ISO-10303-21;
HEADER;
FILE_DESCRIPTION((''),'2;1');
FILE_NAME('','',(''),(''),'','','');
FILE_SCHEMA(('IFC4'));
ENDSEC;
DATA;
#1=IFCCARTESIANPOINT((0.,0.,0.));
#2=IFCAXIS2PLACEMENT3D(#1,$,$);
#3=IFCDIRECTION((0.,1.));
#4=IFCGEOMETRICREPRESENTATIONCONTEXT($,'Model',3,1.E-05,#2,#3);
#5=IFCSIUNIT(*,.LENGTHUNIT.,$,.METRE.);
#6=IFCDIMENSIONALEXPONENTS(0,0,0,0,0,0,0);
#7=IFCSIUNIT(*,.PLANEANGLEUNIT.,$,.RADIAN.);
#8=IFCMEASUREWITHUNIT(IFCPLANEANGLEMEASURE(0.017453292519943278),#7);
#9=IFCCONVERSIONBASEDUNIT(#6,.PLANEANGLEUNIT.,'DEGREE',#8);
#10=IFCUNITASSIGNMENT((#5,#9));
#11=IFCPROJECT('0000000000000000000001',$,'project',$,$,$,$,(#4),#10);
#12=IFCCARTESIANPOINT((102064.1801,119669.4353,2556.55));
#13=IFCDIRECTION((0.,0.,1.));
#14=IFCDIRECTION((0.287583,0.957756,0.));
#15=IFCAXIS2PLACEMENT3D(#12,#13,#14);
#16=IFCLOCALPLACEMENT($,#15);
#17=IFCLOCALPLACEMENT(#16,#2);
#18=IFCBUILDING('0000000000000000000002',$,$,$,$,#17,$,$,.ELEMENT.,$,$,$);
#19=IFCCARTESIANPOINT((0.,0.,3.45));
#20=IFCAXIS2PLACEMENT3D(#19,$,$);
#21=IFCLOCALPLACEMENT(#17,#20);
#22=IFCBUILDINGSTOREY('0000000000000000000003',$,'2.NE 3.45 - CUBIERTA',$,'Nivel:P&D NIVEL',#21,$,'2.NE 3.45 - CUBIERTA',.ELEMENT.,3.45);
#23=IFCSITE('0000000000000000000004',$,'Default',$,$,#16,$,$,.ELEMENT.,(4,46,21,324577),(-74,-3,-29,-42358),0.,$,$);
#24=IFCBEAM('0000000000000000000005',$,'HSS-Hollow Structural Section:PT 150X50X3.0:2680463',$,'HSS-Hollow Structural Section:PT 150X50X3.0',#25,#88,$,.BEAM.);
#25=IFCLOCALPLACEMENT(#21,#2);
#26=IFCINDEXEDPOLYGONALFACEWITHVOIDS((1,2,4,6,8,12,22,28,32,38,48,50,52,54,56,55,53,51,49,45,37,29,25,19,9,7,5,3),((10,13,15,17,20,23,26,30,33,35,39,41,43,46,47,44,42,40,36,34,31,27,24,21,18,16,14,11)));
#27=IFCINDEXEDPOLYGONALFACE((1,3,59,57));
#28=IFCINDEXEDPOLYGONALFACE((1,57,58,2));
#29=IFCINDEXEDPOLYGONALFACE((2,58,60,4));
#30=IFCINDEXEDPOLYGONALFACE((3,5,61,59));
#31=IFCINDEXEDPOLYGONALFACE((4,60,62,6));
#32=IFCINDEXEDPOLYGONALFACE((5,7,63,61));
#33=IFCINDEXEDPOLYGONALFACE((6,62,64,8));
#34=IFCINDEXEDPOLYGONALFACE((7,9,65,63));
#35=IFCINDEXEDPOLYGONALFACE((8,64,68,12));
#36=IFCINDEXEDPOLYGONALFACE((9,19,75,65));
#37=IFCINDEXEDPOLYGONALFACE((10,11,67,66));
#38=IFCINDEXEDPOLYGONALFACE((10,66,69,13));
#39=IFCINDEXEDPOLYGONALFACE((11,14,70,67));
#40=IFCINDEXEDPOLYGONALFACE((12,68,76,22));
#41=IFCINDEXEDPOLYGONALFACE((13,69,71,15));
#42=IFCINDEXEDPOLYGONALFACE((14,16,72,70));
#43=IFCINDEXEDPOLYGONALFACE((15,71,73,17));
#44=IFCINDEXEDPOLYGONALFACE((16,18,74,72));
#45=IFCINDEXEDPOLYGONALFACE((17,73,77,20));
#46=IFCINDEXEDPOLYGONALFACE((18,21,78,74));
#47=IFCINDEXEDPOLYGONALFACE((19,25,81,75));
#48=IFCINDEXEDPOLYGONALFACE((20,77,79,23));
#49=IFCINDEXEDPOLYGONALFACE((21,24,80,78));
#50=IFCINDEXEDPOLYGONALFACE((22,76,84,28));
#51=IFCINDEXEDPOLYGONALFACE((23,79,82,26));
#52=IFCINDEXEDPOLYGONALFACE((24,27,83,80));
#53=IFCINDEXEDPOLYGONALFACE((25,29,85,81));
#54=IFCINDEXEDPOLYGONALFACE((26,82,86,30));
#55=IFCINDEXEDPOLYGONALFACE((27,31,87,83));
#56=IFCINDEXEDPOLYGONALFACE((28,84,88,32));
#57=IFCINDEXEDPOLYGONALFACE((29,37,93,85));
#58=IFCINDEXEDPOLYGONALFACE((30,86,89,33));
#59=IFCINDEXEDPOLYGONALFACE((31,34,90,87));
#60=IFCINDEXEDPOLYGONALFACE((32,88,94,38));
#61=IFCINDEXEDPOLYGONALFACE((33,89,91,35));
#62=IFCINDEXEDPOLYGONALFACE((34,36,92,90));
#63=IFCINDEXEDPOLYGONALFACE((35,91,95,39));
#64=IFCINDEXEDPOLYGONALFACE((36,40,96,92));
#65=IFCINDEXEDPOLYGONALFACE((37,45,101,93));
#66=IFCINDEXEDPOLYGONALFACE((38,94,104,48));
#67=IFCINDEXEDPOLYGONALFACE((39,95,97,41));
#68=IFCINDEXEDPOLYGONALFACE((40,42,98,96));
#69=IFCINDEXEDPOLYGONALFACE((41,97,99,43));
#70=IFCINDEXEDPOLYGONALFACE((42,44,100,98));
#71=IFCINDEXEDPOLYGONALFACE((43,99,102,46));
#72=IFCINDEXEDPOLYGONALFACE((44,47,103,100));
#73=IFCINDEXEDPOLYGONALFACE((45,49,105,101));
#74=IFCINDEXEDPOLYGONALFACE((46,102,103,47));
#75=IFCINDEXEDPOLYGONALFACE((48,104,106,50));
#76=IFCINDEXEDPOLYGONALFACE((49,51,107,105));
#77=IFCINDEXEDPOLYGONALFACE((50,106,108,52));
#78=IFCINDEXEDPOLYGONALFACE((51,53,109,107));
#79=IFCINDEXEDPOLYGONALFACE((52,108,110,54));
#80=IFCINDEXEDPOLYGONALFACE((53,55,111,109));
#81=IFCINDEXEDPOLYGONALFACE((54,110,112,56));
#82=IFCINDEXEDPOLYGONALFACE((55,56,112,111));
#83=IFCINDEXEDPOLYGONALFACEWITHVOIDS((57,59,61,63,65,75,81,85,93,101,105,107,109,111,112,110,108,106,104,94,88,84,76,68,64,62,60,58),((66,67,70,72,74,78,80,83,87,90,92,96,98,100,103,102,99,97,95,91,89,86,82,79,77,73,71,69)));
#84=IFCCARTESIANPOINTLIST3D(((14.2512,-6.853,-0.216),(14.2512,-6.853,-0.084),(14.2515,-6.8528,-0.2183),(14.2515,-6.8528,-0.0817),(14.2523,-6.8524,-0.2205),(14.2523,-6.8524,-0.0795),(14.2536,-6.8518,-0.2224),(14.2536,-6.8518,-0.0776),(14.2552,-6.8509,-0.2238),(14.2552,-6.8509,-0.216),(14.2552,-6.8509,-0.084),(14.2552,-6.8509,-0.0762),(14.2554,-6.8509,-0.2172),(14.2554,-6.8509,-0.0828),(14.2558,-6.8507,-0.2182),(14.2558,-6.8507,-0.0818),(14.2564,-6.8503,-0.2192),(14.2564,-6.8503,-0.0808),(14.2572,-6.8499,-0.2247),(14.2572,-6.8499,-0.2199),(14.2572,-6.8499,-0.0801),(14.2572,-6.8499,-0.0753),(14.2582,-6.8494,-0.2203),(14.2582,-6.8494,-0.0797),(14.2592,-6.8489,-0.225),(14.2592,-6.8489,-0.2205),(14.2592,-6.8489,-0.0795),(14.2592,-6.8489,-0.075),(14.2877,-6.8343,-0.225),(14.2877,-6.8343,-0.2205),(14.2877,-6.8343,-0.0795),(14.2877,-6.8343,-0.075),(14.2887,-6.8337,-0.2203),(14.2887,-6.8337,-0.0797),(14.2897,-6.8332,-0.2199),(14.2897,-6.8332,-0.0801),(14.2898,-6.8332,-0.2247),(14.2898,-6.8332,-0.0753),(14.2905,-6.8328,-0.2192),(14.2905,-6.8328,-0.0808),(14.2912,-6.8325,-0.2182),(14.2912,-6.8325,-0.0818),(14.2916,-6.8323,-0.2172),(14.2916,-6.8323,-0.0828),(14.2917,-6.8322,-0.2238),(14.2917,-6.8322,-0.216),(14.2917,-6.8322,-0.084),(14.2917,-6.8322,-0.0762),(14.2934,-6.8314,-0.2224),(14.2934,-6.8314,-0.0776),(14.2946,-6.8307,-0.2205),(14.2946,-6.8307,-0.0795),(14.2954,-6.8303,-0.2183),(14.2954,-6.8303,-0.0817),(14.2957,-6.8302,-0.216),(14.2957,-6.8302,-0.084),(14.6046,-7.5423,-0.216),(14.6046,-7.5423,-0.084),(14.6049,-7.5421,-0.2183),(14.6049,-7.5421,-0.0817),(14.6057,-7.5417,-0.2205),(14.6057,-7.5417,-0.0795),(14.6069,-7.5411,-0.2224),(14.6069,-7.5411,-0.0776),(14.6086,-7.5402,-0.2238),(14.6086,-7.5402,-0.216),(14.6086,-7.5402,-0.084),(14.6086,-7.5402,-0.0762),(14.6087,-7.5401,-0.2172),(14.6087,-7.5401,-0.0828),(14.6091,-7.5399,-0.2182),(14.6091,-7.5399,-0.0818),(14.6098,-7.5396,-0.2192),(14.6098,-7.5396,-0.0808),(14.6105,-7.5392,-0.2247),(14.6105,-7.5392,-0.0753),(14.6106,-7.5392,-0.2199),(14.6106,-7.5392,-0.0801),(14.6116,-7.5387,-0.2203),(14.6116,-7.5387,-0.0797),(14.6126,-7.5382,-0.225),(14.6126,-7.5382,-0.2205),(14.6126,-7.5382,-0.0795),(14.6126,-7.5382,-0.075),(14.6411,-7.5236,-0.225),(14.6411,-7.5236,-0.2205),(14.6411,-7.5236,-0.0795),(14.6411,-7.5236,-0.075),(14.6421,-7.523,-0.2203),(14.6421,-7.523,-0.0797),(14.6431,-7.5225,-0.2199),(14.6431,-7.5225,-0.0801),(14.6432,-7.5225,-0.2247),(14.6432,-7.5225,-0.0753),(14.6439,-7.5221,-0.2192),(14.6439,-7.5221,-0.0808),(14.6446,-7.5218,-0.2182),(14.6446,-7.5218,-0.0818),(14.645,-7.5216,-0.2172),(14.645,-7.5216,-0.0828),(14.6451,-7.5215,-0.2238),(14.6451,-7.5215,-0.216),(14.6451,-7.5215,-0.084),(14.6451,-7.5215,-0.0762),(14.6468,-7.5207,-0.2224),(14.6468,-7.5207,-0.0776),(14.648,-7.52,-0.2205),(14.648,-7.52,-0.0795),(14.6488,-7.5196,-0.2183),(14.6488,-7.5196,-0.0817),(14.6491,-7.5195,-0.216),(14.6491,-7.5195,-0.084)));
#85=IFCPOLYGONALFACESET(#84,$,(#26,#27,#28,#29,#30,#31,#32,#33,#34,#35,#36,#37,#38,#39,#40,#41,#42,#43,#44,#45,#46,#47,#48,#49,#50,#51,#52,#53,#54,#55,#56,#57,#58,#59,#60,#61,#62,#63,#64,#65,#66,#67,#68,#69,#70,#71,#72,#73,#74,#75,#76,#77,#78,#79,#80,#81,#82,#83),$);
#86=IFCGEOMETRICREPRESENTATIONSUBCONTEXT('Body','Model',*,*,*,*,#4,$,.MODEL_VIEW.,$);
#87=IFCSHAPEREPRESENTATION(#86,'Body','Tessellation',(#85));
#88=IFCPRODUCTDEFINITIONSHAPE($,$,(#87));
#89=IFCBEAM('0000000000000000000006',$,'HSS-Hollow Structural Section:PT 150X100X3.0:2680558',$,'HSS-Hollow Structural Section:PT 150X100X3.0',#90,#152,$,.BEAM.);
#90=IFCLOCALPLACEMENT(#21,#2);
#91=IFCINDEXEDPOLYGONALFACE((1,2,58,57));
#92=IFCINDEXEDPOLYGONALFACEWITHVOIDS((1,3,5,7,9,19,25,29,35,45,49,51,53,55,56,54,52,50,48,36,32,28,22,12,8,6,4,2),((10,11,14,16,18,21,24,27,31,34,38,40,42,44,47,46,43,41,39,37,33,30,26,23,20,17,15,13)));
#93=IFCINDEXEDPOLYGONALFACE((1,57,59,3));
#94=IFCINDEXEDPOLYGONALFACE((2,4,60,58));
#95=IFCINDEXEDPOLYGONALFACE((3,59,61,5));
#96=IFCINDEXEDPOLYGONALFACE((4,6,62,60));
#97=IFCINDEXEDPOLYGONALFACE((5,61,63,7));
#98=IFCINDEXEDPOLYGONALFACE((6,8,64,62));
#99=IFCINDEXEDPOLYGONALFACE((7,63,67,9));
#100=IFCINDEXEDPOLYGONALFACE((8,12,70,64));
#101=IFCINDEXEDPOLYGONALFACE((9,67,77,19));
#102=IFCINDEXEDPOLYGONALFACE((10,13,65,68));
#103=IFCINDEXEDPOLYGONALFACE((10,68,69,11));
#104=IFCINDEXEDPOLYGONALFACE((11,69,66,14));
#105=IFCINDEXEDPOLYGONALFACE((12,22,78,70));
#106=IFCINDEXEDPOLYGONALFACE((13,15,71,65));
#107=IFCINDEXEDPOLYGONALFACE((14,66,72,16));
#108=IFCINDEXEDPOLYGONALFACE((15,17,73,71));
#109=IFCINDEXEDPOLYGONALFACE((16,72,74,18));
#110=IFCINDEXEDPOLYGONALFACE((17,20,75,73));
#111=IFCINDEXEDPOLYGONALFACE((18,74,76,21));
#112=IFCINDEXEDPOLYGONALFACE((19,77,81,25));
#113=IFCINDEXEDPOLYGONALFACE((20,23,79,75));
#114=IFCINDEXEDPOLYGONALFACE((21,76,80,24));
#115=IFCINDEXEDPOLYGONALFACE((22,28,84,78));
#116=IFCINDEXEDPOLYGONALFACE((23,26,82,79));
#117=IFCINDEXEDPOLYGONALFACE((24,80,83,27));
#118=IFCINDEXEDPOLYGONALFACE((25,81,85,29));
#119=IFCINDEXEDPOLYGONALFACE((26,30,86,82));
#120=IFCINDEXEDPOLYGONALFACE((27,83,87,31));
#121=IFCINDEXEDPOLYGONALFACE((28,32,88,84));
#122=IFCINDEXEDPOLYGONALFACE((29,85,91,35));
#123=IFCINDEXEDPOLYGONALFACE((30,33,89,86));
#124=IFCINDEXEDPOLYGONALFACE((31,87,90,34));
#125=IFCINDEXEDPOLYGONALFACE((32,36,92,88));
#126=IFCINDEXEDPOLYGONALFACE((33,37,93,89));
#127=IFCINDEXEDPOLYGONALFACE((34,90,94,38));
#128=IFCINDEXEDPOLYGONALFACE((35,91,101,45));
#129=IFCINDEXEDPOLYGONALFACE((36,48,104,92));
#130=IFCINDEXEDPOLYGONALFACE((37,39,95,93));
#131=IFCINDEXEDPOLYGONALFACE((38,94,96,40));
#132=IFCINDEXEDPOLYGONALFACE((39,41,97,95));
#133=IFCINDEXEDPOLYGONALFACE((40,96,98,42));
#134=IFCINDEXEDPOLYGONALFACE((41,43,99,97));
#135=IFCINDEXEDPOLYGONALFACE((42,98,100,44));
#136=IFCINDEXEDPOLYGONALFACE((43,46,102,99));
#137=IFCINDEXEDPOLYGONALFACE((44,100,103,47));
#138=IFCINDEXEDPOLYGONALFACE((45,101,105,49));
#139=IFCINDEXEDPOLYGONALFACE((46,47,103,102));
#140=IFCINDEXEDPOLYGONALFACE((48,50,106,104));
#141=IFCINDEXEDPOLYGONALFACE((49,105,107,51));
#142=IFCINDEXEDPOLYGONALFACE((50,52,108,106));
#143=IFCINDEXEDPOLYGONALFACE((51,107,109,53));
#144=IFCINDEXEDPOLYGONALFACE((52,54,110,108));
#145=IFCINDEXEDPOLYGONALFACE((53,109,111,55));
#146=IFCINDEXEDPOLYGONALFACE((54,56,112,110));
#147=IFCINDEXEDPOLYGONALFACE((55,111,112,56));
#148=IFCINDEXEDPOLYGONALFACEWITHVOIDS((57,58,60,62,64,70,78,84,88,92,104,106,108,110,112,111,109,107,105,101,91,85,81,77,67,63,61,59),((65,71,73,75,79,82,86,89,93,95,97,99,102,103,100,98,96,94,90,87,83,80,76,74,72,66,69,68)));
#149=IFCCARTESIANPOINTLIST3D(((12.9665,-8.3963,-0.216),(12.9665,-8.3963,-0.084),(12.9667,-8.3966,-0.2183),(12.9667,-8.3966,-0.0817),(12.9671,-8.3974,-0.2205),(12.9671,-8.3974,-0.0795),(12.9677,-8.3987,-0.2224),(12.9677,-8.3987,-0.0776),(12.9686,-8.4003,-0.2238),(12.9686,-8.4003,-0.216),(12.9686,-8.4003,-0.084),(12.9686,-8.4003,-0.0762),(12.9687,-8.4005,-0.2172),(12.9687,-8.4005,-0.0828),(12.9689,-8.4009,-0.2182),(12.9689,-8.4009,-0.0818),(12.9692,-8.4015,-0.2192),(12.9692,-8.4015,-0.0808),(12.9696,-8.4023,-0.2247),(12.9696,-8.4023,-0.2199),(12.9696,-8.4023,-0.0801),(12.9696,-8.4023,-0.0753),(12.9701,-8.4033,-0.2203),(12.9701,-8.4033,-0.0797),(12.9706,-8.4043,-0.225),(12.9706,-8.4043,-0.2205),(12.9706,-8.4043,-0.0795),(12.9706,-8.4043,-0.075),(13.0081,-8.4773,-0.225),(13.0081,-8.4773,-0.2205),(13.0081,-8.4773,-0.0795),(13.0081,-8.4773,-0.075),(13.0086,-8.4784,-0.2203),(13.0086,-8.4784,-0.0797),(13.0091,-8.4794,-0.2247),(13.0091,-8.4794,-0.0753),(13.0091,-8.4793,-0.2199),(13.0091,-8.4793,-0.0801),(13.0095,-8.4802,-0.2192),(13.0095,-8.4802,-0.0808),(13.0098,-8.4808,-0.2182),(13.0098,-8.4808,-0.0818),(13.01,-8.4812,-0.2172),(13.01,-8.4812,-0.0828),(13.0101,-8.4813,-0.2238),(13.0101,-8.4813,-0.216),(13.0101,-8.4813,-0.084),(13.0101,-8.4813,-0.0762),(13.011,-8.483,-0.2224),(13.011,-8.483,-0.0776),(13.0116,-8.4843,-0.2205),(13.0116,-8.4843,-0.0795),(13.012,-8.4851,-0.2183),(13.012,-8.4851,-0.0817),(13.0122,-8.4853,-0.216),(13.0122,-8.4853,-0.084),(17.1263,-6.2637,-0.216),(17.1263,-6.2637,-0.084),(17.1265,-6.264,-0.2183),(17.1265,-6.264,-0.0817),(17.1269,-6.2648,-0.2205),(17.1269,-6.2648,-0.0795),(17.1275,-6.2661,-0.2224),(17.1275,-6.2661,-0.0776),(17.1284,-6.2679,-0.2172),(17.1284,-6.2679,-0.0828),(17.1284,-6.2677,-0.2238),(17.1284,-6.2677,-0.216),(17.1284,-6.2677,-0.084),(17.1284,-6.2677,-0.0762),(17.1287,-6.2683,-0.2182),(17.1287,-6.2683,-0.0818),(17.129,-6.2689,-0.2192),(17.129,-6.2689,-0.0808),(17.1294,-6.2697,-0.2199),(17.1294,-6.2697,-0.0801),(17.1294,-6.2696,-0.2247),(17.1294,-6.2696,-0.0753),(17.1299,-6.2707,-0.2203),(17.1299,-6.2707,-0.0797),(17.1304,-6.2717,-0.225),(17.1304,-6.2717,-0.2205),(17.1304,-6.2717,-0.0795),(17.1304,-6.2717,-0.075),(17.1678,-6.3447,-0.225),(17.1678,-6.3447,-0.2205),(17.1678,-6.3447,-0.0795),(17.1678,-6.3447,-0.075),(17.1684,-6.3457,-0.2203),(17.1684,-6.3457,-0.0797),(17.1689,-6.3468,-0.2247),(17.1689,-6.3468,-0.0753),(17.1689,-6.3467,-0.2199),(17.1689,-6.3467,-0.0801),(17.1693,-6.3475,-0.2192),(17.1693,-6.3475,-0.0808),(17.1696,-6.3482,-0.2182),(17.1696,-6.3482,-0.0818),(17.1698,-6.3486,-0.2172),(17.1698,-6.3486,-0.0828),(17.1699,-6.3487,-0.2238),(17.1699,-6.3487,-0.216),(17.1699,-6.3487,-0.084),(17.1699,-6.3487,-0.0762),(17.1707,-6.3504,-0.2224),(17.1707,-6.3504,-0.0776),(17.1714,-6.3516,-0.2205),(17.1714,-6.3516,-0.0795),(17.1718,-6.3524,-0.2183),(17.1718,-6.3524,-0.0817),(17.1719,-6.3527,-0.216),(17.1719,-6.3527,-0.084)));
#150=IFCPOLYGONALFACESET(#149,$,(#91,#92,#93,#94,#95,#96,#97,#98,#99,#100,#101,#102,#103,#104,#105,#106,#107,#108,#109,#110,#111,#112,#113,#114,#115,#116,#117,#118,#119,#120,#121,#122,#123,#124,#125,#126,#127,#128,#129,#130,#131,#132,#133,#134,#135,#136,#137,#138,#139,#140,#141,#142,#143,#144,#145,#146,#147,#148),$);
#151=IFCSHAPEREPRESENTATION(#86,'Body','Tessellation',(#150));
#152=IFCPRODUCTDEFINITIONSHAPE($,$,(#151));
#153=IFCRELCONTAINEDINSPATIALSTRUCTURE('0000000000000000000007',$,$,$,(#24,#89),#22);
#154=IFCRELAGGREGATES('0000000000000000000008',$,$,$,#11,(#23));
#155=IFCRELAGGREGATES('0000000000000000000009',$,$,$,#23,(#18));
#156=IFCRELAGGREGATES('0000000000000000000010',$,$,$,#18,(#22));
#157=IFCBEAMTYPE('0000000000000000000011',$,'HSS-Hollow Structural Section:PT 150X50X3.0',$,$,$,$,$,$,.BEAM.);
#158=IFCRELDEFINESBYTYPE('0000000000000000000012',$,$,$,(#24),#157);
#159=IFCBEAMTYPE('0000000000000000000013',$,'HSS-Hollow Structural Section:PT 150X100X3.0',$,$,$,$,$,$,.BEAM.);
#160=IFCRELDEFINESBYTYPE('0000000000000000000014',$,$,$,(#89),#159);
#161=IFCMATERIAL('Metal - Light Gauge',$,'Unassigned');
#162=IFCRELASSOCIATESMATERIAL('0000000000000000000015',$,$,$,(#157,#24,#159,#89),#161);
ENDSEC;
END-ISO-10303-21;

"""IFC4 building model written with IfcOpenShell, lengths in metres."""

from ifc_helpers import new_model, entity, si_unit, converted_unit, direction, frame, origin, place, context, subcontext, project, spatial, line, arc, indexed_curve, outline, extrude, source, transform, mapped, material, type_object, type_shapes, element, save


model = new_model("IFC4")

# Units and contexts
model_context = context("Model", 3, precision=1e-05, world=origin(), true_north=direction((0.0, 1.0)))
body_context = subcontext(model_context, "Body", "Model", "MODEL_VIEW")
ifc_project = project(units=[si_unit("LENGTHUNIT", "METRE"), converted_unit("PLANEANGLEUNIT", "DEGREE", entity("IfcPlaneAngleMeasure", 0.017453292519943278), si_unit("PLANEANGLEUNIT", "RADIAN"), dimensions=[0, 0, 0, 0, 0, 0, 0])], contexts=[model_context])

# Site, building, storey
site_placement = place(None, frame((102064.1801, 119669.4353, 2556.55), z_axis=(0.0, 0.0, 1.0), x_axis=(0.287583, 0.957756, 0.0)))
site = spatial("IfcSite", under=ifc_project, at=site_placement, Name="Default", CompositionType="ELEMENT", RefLatitude=(4, 46, 21, 324577), RefLongitude=(-74, -3, -29, -42358), RefElevation=0.0)
building_placement = place(site_placement, origin())
building = spatial("IfcBuilding", under=site, at=building_placement, CompositionType="ELEMENT")
storey_placement = place(building_placement, frame((0.0, 0.0, 3.45)))
storey = spatial("IfcBuildingStorey", under=building, at=storey_placement, Name="2.NE 3.45 - CUBIERTA", ObjectType="Nivel:P&D NIVEL", LongName="2.NE 3.45 - CUBIERTA", CompositionType="ELEMENT", Elevation=3.45)

# Beams
ifc_material_1 = material(Name="Metal - Light Gauge", Category="Unassigned")
beam_type_1 = type_object("IfcBeamType", Name="HSS-Hollow Structural Section:PT 150X50X3.0", PredefinedType="BEAM", material=ifc_material_1)
shared_shape_1 = source(origin(), body_context, "Body", "SweptSolid", [
    extrude(outline(indexed_curve([(-0.025, -0.066), (-0.0224, -0.0724), (-0.016, -0.075), (0.016, -0.075), (0.0224, -0.0724), (0.025, -0.066), (0.025, 0.066), (0.0224, 0.0724), (0.016, 0.075), (-0.016, 0.075), (-0.0224, 0.0724), (-0.025, 0.066)], segments=[arc(1, 2, 3), line(3, 4), arc(4, 5, 6), line(6, 7), arc(7, 8, 9), line(9, 10), arc(10, 11, 12), line(12, 1)], self_intersect=False), holes=[indexed_curve([(0.016, -0.0705), (-0.016, -0.0705), (-0.0192, -0.0692), (-0.0205, -0.066), (-0.0205, 0.066), (-0.0192, 0.0692), (-0.016, 0.0705), (0.016, 0.0705), (0.0192, 0.0692), (0.0205, 0.066), (0.0205, -0.066), (0.0192, -0.0692)], segments=[line(1, 2), arc(2, 3, 4), line(4, 5), arc(5, 6, 7), line(7, 8), arc(8, 9, 10), line(10, 11), arc(11, 12, 1)], self_intersect=False)]), frame((-0.3873, 0.0, 0.0), z_axis=(1.0, 0.0, 0.0), x_axis=(0.0, -1.0, 0.0)), (0.0, 0.0, 1.0), 0.7746),
])
type_shapes(beam_type_1, [shared_shape_1])
for number, where, z_axis, x_axis, name in (
    (1, (14.4502, -7.1862, -0.15), (0.0, 0.0, 1.0), (-0.456217, 0.889869, 0.0), "HSS-Hollow Structural Section:PT 150X50X3.0:2680463"),
):
    element("IfcBeam", number, at=place(storey_placement, frame(where, z_axis=z_axis, x_axis=x_axis)), inside=storey, type_object=beam_type_1, material=ifc_material_1, Name=name, ObjectType="HSS-Hollow Structural Section:PT 150X50X3.0", PredefinedType="BEAM", context=body_context, shape_type="MappedRepresentation", body=[
        mapped(shared_shape_1, transform((0.0, 0.0, 0.0), scale=1.0)),
    ])
beam_type_2 = type_object("IfcBeamType", Name="HSS-Hollow Structural Section:PT 150X100X3.0", PredefinedType="BEAM", material=ifc_material_1)
shared_shape_2 = source(origin(), body_context, "Body", "SweptSolid", [
    extrude(outline(indexed_curve([(-0.05, -0.066), (-0.0474, -0.0724), (-0.041, -0.075), (0.041, -0.075), (0.0474, -0.0724), (0.05, -0.066), (0.05, 0.066), (0.0474, 0.0724), (0.041, 0.075), (-0.041, 0.075), (-0.0474, 0.0724), (-0.05, 0.066)], segments=[arc(1, 2, 3), line(3, 4), arc(4, 5, 6), line(6, 7), arc(7, 8, 9), line(9, 10), arc(10, 11, 12), line(12, 1)], self_intersect=False), holes=[indexed_curve([(0.041, -0.0705), (-0.041, -0.0705), (-0.0442, -0.0692), (-0.0455, -0.066), (-0.0455, 0.066), (-0.0442, 0.0692), (-0.041, 0.0705), (0.041, 0.0705), (0.0442, 0.0692), (0.0455, 0.066), (0.0455, -0.066), (0.0442, -0.0692)], segments=[line(1, 2), arc(2, 3, 4), line(4, 5), arc(5, 6, 7), line(7, 8), arc(8, 9, 10), line(10, 11), arc(11, 12, 1)], self_intersect=False)]), frame((-2.3373, 0.0, 0.0), z_axis=(1.0, 0.0, 0.0), x_axis=(0.0, -1.0, 0.0)), (0.0, 0.0, 1.0), 4.6746),
])
type_shapes(beam_type_2, [shared_shape_2])
for number, where, z_axis, x_axis, name in (
    (2, (15.0692, -7.3745, -0.15), (0.0, 0.0, 1.0), (0.889869, 0.456217, 0.0), "HSS-Hollow Structural Section:PT 150X100X3.0:2680558"),
):
    element("IfcBeam", number, at=place(storey_placement, frame(where, z_axis=z_axis, x_axis=x_axis)), inside=storey, type_object=beam_type_2, material=ifc_material_1, Name=name, ObjectType="HSS-Hollow Structural Section:PT 150X100X3.0", PredefinedType="BEAM", context=body_context, shape_type="MappedRepresentation", body=[
        mapped(shared_shape_2, transform((0.0, 0.0, 0.0), scale=1.0)),
    ])

save(model, "model.ifc")
